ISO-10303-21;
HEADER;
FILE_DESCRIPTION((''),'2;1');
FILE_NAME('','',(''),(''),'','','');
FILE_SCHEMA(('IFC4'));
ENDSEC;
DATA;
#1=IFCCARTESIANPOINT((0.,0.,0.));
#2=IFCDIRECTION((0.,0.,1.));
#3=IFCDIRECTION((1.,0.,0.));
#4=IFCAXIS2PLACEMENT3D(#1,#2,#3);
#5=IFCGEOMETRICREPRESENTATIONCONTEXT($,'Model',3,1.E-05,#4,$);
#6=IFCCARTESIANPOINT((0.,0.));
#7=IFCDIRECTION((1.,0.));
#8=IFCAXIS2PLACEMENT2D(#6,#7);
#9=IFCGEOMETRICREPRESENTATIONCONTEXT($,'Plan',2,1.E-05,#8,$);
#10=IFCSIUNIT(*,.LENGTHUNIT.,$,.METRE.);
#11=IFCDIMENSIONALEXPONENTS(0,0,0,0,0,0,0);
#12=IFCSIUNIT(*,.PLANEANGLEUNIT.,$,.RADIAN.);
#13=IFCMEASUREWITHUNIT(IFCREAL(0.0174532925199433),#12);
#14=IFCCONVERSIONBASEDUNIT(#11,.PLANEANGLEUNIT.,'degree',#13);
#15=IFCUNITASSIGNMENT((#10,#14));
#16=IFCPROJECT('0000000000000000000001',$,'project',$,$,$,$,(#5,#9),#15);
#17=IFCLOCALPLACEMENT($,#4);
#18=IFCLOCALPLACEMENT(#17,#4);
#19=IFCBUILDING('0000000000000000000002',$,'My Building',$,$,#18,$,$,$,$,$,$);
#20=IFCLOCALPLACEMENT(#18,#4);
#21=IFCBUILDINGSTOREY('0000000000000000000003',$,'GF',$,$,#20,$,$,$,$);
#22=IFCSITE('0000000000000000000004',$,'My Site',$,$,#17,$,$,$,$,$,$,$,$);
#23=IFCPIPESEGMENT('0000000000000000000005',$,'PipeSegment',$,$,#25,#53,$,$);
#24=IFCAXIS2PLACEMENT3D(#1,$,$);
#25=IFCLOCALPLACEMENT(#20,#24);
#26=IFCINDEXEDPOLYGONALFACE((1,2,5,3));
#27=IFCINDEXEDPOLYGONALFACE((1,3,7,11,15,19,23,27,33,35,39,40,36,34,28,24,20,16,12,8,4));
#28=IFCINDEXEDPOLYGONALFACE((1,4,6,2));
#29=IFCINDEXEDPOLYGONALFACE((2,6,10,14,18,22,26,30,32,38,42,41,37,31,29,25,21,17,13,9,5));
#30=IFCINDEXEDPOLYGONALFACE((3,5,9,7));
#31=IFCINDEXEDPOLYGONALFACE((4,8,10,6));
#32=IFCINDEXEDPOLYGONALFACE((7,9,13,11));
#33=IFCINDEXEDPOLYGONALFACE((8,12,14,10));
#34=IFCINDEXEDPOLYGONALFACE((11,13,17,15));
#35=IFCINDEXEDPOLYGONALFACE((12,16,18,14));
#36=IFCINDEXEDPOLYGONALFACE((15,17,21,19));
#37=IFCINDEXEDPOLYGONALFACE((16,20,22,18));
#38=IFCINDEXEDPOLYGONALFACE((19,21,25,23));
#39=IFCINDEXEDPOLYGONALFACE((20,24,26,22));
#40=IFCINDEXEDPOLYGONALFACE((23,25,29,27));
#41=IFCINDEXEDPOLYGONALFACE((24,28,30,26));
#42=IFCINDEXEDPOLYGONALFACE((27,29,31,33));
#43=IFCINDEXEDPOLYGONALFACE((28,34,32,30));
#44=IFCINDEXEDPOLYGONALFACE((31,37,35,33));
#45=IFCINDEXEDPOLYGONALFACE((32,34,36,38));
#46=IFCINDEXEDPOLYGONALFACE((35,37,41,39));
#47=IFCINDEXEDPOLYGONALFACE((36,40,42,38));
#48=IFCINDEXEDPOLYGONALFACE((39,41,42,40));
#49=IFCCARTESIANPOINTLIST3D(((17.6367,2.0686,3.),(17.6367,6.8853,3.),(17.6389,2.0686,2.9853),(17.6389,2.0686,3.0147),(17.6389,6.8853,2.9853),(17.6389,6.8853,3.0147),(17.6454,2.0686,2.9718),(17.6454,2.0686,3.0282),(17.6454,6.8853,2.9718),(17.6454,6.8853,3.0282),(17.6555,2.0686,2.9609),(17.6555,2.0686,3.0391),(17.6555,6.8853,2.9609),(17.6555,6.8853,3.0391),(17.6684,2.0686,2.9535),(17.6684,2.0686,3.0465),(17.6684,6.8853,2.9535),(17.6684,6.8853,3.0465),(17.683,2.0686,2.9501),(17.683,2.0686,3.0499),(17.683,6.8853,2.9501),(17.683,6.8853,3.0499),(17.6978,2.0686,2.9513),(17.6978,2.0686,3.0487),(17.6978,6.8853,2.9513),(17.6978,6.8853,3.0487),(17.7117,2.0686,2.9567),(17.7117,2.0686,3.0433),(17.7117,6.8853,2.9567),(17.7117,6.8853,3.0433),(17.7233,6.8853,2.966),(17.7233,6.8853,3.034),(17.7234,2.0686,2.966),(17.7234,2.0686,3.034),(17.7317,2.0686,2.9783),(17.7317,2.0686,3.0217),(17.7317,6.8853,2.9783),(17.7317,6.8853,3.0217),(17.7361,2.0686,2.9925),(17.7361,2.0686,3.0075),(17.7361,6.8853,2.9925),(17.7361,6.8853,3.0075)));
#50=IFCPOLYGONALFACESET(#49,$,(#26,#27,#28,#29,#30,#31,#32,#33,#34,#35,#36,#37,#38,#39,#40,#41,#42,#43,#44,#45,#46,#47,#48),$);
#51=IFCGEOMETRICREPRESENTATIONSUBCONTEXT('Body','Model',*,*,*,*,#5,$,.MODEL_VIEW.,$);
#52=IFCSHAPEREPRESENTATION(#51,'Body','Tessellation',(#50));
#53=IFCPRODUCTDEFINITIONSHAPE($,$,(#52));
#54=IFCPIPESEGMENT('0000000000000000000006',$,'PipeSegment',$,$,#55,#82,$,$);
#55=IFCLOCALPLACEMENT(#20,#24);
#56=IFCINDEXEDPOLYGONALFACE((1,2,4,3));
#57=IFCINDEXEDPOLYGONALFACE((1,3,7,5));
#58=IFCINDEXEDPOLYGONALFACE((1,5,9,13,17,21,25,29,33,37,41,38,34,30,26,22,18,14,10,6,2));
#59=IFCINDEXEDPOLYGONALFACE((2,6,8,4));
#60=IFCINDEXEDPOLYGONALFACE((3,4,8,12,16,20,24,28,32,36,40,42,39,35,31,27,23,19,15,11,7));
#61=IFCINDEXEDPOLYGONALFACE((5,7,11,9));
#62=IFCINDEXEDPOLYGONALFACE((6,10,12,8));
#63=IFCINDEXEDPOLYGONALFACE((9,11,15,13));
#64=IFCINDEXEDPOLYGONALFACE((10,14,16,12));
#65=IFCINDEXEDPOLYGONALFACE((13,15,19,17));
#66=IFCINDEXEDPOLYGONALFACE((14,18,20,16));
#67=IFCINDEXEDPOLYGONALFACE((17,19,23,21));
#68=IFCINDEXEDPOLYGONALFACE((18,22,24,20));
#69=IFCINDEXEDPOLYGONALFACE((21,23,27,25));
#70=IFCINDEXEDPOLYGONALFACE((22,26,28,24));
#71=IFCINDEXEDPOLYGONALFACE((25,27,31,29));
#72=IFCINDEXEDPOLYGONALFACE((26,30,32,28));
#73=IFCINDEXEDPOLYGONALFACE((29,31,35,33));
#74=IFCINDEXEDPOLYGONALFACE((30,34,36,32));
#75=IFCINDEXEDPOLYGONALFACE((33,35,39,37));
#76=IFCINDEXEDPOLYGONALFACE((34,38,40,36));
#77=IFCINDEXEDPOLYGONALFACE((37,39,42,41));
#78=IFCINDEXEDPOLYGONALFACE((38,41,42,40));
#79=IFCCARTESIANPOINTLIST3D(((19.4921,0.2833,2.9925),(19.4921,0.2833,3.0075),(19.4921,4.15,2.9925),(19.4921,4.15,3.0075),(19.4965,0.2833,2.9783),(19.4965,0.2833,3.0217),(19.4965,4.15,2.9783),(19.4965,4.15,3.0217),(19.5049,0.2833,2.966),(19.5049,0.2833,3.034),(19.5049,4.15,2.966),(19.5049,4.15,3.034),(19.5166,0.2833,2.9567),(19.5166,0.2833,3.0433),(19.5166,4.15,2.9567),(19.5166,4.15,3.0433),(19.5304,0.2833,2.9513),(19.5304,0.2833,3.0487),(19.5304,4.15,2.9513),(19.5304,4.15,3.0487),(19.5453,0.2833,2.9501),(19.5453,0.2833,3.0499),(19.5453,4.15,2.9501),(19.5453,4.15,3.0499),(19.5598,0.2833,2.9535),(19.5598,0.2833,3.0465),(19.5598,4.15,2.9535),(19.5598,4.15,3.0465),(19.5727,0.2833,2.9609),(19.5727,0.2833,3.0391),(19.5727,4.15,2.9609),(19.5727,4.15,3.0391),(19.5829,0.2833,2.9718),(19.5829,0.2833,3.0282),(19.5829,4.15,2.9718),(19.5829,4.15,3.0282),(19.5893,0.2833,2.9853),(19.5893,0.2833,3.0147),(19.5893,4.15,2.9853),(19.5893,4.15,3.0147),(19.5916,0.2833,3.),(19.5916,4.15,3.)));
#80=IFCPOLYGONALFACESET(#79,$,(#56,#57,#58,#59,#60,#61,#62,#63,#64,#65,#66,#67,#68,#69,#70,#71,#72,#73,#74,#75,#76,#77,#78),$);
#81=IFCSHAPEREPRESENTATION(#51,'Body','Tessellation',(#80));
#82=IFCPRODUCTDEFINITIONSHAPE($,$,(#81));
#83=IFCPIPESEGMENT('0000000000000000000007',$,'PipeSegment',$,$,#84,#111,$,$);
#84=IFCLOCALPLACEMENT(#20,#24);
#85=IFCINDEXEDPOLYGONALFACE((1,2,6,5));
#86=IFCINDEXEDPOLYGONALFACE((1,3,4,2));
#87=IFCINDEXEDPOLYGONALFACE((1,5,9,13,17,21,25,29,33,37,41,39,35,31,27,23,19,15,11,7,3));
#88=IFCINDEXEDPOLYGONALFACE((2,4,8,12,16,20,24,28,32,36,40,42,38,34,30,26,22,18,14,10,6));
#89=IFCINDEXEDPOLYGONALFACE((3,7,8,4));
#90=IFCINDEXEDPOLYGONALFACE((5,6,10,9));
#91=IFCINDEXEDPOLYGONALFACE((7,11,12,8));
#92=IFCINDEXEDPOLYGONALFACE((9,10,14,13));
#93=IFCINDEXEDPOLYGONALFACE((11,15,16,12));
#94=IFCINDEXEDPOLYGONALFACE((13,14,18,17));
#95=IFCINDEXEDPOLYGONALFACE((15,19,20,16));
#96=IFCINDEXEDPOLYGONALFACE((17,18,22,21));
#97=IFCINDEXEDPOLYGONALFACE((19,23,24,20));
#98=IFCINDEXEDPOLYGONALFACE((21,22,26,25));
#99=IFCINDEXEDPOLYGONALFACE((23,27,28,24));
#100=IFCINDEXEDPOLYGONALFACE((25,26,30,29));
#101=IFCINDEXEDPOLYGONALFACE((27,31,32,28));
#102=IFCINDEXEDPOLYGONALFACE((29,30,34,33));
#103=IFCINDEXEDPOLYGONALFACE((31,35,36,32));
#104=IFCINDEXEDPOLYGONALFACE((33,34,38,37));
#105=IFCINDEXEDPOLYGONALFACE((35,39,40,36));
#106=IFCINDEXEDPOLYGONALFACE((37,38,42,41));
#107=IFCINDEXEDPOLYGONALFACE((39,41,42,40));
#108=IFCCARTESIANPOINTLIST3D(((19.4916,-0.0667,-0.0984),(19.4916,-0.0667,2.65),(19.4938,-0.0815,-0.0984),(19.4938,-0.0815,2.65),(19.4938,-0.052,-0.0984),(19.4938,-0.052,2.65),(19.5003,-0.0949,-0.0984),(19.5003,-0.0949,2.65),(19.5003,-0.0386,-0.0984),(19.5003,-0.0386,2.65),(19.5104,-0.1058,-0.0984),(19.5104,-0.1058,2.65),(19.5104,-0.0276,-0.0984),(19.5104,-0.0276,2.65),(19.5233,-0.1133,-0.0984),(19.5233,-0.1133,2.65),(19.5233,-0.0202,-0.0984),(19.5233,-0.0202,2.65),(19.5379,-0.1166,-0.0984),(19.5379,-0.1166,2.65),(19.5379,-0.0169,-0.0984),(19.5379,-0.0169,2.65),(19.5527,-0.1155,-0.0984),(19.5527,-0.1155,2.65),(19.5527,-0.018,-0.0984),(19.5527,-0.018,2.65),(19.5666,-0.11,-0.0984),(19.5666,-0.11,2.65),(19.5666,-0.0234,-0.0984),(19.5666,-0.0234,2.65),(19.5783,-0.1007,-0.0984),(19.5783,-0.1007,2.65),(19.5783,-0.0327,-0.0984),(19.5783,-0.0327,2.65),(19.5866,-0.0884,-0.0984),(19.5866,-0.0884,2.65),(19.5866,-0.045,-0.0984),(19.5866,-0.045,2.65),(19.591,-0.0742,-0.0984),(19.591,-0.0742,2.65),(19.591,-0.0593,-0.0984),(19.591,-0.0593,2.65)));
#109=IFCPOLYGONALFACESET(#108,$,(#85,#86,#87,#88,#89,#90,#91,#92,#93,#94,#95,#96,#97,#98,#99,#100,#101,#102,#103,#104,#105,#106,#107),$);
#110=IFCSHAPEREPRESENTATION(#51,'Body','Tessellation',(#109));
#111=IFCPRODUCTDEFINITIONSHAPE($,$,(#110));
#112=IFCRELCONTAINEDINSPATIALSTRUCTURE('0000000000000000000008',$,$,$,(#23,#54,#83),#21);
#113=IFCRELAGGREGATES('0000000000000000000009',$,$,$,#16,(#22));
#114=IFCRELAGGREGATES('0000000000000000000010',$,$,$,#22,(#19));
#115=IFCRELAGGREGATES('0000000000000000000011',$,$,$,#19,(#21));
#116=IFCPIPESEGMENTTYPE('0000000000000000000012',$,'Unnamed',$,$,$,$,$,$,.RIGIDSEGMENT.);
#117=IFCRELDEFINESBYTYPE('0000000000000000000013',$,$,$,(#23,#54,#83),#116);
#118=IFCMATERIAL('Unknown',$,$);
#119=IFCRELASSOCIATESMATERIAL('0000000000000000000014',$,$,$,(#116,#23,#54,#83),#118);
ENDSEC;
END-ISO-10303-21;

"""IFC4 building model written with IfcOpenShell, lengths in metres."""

from ifc_helpers import new_model, entity, si_unit, converted_unit, frame, origin_with_axes, origin_2d_with_axis, place, context, subcontext, project, spatial, circle, extrude, material, material_profile, profile_set, profile_usage, type_object, element, save


model = new_model("IFC4")

# Units and contexts
model_context = context("Model", 3, precision=1e-05, world=origin_with_axes())
plan_context = context("Plan", 2, precision=1e-05, world=origin_2d_with_axis())
body_context_1 = subcontext(model_context, "Body", "Model", "MODEL_VIEW")
ifc_project = project(units=[si_unit("LENGTHUNIT", "METRE"), converted_unit("PLANEANGLEUNIT", "degree", entity("IfcReal", 0.0174532925199433), si_unit("PLANEANGLEUNIT", "RADIAN"), dimensions=[0, 0, 0, 0, 0, 0, 0])], contexts=[model_context, plan_context])

# Site, building, storey
site_placement = place(None, origin_with_axes())
site = spatial("IfcSite", under=ifc_project, at=site_placement, Name="My Site")
building_placement = place(site_placement, origin_with_axes())
building = spatial("IfcBuilding", under=site, at=building_placement, Name="My Building")
storey_placement = place(building_placement, origin_with_axes())
storey = spatial("IfcBuildingStorey", under=building, at=storey_placement, Name="GF")

# Shared definitions
ifc_material = material(Name="Unknown")

# Pipe segments
ifc_material_profile = material_profile(ifc_material, circle(Radius=0.05))
ifc_profile_set = profile_set([ifc_material_profile])
pipe_segment_type = type_object("IfcPipeSegmentType", Name="Unnamed", PredefinedType="RIGIDSEGMENT", material=ifc_profile_set)
ifc_profile_usage_1 = profile_usage(ifc_profile_set, cardinal=5)
pipe_segment_1_placement = place(storey_placement, frame((17.6867, 6.8853, 3.0), z_axis=(0.0, -1.0, 0.0), x_axis=(-1.0, 0.0, 0.0)))
element("IfcPipeSegment", 1, at=pipe_segment_1_placement, inside=storey, type_object=pipe_segment_type, material=ifc_profile_usage_1, Name="PipeSegment", context=body_context_1, shape_type="SweptSolid", body=[
    extrude(circle(Radius=0.05), origin_with_axes(), (0.0, 0.0, 1.0), 4.8167),
])
ifc_profile_usage_2 = profile_usage(ifc_profile_set, cardinal=5)
pipe_segment_2_placement = place(storey_placement, frame((19.5416, 4.15, 3.0), z_axis=(0.0, -1.0, 0.0), x_axis=(1.0, 0.0, 0.0)))
element("IfcPipeSegment", 2, at=pipe_segment_2_placement, inside=storey, type_object=pipe_segment_type, material=ifc_profile_usage_2, Name="PipeSegment", context=body_context_1, shape_type="SweptSolid", body=[
    extrude(circle(Radius=0.05), origin_with_axes(), (0.0, 0.0, 1.0), 3.8667),
])
ifc_profile_usage_3 = profile_usage(ifc_profile_set, cardinal=5)
pipe_segment_3_placement = place(storey_placement, frame((19.5416, -0.0667, 2.65), z_axis=(0.0, 0.0, -1.0), x_axis=(-1.0, 0.0, 0.0)))
element("IfcPipeSegment", 3, at=pipe_segment_3_placement, inside=storey, type_object=pipe_segment_type, material=ifc_profile_usage_3, Name="PipeSegment", context=body_context_1, shape_type="SweptSolid", body=[
    extrude(circle(Radius=0.05), origin_with_axes(), (0.0, 0.0, 1.0), 2.7484),
])

save(model, "model.ifc")
